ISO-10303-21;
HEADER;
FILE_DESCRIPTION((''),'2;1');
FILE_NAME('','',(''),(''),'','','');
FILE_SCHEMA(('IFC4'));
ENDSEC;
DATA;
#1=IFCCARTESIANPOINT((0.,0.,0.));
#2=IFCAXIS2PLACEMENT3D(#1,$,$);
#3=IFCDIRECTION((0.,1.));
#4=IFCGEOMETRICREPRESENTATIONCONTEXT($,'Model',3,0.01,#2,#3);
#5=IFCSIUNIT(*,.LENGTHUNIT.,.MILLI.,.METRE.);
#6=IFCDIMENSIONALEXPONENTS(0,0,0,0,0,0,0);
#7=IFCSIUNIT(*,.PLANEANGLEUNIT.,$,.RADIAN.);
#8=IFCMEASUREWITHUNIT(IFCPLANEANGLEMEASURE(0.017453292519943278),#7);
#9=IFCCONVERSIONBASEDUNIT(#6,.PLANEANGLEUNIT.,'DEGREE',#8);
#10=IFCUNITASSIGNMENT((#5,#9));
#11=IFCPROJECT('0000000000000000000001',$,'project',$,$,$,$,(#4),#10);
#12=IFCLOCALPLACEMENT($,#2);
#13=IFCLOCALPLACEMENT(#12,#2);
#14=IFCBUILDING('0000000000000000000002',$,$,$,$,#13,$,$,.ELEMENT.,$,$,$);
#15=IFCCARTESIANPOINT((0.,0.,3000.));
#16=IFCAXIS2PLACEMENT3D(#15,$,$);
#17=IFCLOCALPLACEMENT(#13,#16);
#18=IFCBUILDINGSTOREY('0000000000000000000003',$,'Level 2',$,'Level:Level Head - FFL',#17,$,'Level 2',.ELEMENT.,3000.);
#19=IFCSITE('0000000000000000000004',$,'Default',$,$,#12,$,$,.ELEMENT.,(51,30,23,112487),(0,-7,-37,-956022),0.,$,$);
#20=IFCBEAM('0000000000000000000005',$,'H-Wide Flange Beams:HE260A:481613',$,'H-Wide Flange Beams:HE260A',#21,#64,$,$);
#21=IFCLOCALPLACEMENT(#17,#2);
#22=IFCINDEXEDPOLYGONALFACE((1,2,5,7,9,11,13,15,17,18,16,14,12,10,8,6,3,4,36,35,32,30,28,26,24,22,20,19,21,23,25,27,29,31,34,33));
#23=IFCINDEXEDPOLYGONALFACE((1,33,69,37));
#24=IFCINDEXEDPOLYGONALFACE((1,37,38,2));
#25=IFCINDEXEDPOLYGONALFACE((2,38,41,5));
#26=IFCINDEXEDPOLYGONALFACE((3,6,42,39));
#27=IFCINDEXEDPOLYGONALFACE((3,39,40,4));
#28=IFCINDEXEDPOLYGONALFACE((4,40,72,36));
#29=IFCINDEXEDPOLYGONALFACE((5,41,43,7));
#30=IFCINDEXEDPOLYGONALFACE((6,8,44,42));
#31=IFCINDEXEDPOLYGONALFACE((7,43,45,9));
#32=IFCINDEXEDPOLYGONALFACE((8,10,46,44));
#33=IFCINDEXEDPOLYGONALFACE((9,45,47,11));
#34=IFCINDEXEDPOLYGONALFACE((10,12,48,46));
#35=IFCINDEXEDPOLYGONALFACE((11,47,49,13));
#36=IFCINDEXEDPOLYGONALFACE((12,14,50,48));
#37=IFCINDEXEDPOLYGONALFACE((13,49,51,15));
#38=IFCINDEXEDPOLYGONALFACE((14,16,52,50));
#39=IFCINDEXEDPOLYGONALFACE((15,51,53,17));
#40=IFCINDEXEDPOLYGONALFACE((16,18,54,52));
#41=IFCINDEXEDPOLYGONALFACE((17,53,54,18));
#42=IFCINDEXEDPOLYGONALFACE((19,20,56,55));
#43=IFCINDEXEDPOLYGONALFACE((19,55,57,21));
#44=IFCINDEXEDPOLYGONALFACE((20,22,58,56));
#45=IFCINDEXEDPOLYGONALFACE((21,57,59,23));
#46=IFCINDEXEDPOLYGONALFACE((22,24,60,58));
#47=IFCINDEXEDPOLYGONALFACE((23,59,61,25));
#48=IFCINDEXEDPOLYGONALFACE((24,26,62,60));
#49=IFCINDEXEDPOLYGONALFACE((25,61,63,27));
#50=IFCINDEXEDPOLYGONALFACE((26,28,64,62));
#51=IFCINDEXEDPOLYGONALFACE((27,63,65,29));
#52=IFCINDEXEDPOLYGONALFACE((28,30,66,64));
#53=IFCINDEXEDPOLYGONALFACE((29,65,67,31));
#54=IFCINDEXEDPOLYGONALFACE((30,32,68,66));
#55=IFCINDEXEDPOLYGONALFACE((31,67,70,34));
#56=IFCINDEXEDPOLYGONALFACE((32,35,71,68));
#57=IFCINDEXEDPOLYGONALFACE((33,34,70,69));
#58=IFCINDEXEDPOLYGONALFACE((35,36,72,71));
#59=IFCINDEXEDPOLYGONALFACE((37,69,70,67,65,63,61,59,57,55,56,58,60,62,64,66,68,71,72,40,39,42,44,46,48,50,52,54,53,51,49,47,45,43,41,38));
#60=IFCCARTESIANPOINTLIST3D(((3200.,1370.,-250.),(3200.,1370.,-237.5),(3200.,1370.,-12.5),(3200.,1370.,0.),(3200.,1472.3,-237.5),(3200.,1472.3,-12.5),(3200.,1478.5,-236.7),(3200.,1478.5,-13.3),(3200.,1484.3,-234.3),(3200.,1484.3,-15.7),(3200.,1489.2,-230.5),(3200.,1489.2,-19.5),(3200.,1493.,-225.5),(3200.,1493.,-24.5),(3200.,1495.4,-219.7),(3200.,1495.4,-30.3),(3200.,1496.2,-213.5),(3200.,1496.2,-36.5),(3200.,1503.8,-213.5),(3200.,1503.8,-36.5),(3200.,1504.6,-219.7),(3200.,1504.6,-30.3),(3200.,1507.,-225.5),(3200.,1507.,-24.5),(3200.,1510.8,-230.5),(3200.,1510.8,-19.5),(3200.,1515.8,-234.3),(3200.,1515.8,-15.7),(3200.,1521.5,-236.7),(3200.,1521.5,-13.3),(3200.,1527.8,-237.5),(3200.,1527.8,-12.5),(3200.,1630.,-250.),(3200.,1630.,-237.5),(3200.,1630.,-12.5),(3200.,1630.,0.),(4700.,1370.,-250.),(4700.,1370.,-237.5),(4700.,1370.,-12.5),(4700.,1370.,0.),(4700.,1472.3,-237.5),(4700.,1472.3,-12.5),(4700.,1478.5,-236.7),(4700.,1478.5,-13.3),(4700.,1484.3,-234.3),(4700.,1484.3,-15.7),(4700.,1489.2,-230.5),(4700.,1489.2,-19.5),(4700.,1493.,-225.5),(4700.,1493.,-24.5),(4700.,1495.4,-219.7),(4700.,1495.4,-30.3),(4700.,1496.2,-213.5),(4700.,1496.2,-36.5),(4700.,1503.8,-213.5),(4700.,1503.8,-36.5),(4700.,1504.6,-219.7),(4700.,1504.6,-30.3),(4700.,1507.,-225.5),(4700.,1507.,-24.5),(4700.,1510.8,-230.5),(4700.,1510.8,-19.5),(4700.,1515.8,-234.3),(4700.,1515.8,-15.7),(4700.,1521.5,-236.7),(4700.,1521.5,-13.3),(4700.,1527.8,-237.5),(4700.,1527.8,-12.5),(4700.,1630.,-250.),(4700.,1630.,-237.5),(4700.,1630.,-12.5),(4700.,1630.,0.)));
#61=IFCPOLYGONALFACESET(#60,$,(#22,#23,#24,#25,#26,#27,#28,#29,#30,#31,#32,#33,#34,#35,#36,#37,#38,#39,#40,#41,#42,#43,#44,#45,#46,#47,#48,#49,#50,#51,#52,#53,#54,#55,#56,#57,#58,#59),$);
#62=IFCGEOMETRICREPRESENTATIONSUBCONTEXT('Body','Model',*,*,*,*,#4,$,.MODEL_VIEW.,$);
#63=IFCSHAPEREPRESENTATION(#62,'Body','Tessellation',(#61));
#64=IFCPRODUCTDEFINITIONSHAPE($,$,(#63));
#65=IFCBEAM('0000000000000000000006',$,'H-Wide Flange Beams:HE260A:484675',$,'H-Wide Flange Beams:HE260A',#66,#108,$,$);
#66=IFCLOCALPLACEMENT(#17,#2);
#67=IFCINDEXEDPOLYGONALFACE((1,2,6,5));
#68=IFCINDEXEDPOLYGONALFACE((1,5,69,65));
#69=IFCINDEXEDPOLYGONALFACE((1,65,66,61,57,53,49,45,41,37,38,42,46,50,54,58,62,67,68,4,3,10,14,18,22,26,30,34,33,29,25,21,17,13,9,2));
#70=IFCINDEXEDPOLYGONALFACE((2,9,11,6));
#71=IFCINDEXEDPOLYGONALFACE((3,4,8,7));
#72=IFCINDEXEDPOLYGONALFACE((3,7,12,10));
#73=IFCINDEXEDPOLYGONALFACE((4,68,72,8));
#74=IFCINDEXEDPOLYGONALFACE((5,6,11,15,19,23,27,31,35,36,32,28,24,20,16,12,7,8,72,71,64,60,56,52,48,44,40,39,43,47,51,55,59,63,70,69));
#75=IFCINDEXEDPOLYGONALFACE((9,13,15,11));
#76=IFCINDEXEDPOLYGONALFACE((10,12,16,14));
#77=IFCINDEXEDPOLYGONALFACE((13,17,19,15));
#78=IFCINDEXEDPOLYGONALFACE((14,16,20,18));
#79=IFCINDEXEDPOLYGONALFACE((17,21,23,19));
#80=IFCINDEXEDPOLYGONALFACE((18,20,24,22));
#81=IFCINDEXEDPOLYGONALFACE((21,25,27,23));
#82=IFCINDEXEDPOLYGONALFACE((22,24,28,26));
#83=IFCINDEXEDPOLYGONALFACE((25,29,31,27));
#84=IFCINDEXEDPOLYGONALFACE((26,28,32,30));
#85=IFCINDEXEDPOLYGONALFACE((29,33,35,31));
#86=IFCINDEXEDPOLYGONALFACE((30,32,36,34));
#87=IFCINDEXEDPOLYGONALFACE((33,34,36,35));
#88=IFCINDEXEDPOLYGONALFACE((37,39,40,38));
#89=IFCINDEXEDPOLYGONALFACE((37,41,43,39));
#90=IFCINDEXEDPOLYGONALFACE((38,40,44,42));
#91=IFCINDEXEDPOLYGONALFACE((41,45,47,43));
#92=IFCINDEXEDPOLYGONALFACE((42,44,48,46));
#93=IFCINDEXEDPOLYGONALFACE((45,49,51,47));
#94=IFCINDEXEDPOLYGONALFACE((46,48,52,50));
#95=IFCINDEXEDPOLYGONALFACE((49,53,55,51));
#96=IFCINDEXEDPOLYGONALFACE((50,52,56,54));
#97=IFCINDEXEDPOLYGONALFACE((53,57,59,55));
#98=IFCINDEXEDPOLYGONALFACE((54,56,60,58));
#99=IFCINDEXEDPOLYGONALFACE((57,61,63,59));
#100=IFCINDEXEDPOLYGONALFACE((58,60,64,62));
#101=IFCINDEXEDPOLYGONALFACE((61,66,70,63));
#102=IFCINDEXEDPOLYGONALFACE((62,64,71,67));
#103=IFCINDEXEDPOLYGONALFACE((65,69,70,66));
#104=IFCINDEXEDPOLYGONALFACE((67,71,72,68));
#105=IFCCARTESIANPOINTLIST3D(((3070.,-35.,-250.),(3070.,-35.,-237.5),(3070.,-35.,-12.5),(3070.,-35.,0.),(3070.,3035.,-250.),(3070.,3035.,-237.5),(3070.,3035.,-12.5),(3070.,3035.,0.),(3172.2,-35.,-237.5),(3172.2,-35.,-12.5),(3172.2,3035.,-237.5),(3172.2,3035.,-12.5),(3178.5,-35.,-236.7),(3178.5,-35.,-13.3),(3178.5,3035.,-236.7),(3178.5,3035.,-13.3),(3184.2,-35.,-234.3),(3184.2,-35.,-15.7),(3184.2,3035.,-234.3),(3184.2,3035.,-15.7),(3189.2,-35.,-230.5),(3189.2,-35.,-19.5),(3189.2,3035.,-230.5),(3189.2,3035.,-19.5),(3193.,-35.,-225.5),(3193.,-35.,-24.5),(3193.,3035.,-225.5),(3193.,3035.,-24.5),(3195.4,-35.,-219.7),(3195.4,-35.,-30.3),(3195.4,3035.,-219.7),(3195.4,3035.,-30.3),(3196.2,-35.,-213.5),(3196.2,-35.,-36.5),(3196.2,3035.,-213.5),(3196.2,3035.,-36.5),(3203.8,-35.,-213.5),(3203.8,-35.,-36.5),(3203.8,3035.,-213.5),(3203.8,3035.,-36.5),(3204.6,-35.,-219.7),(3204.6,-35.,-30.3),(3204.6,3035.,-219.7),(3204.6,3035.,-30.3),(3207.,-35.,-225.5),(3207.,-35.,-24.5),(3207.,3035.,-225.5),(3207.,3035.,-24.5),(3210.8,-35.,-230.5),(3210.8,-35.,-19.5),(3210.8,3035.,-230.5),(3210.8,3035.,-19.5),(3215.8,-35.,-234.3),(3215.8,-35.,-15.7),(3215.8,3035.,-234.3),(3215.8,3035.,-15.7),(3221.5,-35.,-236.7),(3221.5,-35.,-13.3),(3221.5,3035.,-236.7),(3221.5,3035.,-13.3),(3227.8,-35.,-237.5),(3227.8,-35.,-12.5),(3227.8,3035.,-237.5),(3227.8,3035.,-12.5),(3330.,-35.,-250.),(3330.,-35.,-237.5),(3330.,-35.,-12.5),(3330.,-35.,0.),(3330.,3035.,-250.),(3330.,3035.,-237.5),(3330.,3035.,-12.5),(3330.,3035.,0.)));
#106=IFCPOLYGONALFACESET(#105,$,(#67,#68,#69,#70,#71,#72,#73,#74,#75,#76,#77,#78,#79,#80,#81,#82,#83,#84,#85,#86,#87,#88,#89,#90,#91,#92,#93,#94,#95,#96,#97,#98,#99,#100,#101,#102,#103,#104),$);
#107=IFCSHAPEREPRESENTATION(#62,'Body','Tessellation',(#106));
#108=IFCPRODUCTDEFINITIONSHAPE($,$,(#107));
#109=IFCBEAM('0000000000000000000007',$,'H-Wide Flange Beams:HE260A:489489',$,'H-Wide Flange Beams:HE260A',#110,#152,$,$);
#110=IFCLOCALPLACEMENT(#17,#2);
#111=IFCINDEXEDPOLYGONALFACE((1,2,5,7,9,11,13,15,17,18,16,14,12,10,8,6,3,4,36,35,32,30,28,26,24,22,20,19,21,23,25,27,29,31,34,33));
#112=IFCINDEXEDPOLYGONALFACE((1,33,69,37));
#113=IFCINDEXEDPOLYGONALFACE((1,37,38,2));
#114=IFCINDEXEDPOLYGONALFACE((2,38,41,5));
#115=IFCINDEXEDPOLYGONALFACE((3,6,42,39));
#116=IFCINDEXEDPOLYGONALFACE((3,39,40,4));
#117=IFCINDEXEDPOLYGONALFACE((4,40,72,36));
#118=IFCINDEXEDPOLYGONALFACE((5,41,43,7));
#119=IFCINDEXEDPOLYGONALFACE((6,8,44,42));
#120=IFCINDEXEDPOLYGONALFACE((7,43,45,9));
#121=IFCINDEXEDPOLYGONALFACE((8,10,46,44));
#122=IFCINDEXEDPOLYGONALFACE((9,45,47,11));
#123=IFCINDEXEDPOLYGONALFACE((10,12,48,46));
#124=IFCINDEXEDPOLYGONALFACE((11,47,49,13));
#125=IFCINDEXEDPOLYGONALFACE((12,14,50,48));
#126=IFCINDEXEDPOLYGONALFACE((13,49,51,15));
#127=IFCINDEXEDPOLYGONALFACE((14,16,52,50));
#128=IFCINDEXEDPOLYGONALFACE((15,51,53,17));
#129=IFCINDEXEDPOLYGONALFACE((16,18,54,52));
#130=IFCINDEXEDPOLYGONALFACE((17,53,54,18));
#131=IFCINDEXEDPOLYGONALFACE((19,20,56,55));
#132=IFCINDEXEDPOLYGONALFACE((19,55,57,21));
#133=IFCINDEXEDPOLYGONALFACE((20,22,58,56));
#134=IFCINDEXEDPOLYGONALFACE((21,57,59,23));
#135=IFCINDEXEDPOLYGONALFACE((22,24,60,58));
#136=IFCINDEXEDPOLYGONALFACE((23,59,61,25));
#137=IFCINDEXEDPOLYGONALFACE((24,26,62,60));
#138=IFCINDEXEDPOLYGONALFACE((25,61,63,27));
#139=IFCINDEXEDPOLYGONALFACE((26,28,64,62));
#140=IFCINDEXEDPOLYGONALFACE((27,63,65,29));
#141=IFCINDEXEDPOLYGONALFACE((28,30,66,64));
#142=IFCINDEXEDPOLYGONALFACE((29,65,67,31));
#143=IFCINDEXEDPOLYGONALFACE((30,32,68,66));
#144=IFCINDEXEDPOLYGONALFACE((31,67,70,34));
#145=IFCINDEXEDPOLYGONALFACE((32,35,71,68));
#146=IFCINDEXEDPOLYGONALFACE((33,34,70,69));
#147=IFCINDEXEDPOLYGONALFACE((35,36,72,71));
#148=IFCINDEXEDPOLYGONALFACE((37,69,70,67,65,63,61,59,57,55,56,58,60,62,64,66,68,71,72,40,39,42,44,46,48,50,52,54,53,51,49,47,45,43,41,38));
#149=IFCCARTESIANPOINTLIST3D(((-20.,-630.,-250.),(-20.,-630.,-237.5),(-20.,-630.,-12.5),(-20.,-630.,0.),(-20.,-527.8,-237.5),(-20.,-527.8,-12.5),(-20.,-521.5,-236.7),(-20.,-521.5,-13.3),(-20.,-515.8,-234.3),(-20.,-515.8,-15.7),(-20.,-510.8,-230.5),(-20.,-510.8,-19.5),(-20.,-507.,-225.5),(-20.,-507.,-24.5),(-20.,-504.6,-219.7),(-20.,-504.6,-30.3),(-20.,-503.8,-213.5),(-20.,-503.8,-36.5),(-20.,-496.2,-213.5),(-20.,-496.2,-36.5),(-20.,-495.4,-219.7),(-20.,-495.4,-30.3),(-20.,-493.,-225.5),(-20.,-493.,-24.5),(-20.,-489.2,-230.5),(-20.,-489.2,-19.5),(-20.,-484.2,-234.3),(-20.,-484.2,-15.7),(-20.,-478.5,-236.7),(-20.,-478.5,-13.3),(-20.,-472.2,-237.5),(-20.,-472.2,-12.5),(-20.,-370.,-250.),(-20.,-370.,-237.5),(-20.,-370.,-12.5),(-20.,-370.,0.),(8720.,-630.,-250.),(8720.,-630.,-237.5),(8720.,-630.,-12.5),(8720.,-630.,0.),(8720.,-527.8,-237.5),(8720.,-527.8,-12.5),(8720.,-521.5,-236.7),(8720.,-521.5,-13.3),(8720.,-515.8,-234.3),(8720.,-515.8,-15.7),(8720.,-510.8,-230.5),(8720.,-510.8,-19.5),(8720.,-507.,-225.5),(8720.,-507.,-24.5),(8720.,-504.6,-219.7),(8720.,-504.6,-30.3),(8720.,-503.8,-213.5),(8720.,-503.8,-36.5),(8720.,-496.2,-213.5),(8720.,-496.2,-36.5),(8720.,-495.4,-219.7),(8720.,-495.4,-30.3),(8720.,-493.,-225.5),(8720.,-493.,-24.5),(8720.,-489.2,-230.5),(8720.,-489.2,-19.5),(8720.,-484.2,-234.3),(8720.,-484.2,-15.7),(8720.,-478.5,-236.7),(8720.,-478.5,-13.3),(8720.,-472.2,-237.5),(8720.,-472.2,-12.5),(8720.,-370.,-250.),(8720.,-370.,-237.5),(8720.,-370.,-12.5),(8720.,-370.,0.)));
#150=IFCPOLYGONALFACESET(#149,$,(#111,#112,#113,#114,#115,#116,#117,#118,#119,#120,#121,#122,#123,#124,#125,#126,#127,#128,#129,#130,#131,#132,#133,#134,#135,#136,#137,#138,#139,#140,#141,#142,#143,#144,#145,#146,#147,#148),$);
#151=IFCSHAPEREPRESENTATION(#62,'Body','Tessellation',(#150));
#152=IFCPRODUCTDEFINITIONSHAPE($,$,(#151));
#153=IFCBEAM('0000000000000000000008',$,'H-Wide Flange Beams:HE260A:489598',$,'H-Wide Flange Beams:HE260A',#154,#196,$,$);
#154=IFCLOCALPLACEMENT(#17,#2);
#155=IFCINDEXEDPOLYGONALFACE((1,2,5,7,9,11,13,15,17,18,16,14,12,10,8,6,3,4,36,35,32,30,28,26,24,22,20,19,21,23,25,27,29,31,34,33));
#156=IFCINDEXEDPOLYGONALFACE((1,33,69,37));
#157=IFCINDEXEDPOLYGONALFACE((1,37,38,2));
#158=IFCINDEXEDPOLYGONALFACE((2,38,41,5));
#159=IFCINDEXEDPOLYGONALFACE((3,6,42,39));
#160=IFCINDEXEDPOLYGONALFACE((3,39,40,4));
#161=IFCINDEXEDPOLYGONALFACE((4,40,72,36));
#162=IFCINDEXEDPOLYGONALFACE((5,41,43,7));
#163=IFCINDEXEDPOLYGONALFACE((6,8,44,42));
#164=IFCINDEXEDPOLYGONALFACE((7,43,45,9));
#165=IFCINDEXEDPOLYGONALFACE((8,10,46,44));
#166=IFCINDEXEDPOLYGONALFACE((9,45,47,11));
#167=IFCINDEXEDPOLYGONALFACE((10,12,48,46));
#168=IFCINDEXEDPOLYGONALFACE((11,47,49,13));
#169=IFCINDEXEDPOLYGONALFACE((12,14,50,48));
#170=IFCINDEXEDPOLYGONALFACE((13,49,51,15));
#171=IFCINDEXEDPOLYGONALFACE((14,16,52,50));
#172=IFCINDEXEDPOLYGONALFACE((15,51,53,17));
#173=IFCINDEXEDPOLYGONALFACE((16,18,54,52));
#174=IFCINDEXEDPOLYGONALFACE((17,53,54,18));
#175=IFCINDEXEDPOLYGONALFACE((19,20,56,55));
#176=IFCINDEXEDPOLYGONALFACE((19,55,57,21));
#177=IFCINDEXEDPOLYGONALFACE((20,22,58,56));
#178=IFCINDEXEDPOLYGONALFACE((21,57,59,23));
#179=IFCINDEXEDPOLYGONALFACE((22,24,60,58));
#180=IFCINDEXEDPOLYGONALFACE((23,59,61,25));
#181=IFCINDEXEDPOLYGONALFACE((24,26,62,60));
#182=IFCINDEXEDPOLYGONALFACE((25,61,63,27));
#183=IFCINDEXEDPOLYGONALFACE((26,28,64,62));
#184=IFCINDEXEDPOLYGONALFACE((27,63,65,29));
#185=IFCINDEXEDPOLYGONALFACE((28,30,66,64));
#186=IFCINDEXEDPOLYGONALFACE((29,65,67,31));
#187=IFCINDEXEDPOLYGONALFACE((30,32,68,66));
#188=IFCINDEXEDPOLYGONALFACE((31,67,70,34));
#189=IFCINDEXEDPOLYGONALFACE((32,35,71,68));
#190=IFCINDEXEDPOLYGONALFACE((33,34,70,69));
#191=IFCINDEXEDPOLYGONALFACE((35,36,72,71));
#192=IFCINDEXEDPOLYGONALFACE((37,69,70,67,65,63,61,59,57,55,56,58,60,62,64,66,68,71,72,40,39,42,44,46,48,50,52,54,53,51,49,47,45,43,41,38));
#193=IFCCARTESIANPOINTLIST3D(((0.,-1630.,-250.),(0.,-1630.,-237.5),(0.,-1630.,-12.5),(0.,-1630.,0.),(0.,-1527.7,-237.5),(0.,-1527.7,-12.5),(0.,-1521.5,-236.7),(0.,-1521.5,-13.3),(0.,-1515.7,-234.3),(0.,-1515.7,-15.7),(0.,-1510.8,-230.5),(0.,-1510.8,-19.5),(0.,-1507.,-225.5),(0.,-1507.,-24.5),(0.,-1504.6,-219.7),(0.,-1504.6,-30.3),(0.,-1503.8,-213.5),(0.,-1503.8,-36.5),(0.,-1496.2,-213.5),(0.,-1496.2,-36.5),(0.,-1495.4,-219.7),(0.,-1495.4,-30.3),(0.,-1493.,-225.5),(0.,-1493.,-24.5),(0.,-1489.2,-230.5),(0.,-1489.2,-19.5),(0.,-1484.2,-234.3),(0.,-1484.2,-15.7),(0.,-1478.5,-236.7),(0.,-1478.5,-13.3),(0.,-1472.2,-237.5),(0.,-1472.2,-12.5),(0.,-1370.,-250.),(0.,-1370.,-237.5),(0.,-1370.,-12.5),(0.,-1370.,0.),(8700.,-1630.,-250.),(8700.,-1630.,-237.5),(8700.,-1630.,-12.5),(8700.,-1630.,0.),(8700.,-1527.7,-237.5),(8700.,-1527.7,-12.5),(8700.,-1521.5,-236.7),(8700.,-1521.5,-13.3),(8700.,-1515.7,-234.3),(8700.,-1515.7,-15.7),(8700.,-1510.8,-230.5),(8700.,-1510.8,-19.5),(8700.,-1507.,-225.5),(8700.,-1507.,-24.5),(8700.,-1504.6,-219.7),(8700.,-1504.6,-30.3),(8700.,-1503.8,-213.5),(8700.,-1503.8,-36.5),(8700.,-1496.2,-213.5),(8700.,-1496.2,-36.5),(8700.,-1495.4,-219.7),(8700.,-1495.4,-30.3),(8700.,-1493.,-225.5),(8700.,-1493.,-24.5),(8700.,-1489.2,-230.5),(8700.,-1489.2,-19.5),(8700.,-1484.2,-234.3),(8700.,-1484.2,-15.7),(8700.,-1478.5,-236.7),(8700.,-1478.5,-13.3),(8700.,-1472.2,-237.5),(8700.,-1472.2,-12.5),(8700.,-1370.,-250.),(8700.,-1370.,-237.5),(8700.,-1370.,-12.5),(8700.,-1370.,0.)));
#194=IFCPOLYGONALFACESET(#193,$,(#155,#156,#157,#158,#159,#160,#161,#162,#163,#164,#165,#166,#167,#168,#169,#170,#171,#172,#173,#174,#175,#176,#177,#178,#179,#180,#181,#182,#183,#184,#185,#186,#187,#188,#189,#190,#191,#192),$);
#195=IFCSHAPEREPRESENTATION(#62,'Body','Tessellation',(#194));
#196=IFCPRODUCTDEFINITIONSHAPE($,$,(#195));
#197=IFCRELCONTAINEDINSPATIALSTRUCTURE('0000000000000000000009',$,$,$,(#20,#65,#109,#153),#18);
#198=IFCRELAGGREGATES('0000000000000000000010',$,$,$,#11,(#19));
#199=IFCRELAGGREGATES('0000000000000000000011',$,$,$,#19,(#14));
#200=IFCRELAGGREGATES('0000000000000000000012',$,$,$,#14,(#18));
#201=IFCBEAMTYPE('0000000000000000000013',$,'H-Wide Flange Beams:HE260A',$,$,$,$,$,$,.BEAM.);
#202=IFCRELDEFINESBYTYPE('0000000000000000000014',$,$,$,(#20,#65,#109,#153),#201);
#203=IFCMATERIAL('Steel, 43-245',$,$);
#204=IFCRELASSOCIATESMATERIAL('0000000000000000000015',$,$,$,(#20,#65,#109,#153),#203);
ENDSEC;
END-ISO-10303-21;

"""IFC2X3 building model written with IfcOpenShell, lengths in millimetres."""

from ifc_helpers import new_model, entity, si_unit, converted_unit, direction, frame, frame_2d, origin, place, context, subcontext, project, spatial, i_section, extrude, material, type_object, element, save


model = new_model("IFC2X3")

# Units and contexts
model_context = context("Model", 3, precision=0.01, world=origin(), true_north=direction((0.0, 1.0)))
body_context = subcontext(model_context, "Body", "Model", "MODEL_VIEW")
ifc_project = project(units=[si_unit("LENGTHUNIT", "METRE", prefix="MILLI"), converted_unit("PLANEANGLEUNIT", "DEGREE", entity("IfcPlaneAngleMeasure", 0.017453292519943278), si_unit("PLANEANGLEUNIT", "RADIAN"), dimensions=[0, 0, 0, 0, 0, 0, 0])], contexts=[model_context])

# Site, building, storey
site_placement = place(None, origin())
site = spatial("IfcSite", under=ifc_project, at=site_placement, Name="Default", CompositionType="ELEMENT", RefLatitude=(51, 30, 23, 112487), RefLongitude=(0, -7, -37, -956022), RefElevation=0.0)
building_placement = place(site_placement, origin())
building = spatial("IfcBuilding", under=site, at=building_placement, CompositionType="ELEMENT")
storey_placement = place(building_placement, frame((0.0, 0.0, 3000.0)))
storey = spatial("IfcBuildingStorey", under=building, at=storey_placement, Name="Level 2", ObjectType="Level:Level Head - FFL", LongName="Level 2", CompositionType="ELEMENT", Elevation=3000.0)

# Beams
ifc_material = material(Name="Steel, 43-245")
beam_type_1 = type_object("IfcBeamType", Name="H-Wide Flange Beams:HE260A", PredefinedType="BEAM")
beam_1_placement = place(storey_placement, frame((4700.0, 1500.0, 0.0), z_axis=(0.0, 0.0, 1.0), x_axis=(-1.0, 0.0, 0.0)))
element("IfcBeam", 1, at=beam_1_placement, inside=storey, type_object=beam_type_1, material=ifc_material, Name="H-Wide Flange Beams:HE260A:481613", ObjectType="H-Wide Flange Beams:HE260A", context=body_context, shape_type="SweptSolid", body=[
    extrude(i_section(OverallWidth=260.0, OverallDepth=250.0, WebThickness=7.5, FlangeThickness=12.5, FilletRadius=24.0, at=frame_2d((0.0, 0.0), x_axis=(0.0, 1.0))), frame((0.0, 0.0, -125.0), z_axis=(1.0, 0.0, 0.0), x_axis=(0.0, 0.0, -1.0)), (0.0, 0.0, 1.0), 1500.0),
])
beam_2_placement = place(storey_placement, frame((3200.0, 0.0, 0.0), z_axis=(0.0, 0.0, 1.0), x_axis=(0.0, 1.0, 0.0)))
element("IfcBeam", 2, at=beam_2_placement, inside=storey, type_object=beam_type_1, material=ifc_material, Name="H-Wide Flange Beams:HE260A:484675", ObjectType="H-Wide Flange Beams:HE260A", context=body_context, shape_type="SweptSolid", body=[
    extrude(i_section(OverallWidth=260.0, OverallDepth=250.0, WebThickness=7.5, FlangeThickness=12.5, FilletRadius=24.0, at=frame_2d((0.0, 0.0), x_axis=(0.0, 1.0))), frame((-35.0, 0.0, -125.0), z_axis=(1.0, 0.0, 0.0), x_axis=(0.0, 0.0, -1.0)), (0.0, 0.0, 1.0), 3070.0),
])
beam_3_placement = place(storey_placement, frame((0.0, -500.0, 0.0)))
element("IfcBeam", 3, at=beam_3_placement, inside=storey, type_object=beam_type_1, material=ifc_material, Name="H-Wide Flange Beams:HE260A:489489", ObjectType="H-Wide Flange Beams:HE260A", context=body_context, shape_type="SweptSolid", body=[
    extrude(i_section(OverallWidth=260.0, OverallDepth=250.0, WebThickness=7.5, FlangeThickness=12.5, FilletRadius=24.0, at=frame_2d((0.0, 0.0), x_axis=(0.0, 1.0))), frame((-20.0, 0.0, -125.0), z_axis=(1.0, 0.0, 0.0), x_axis=(0.0, 0.0, -1.0)), (0.0, 0.0, 1.0), 8740.0),
])
beam_4_placement = place(storey_placement, frame((0.0, -1500.0, 0.0)))
element("IfcBeam", 4, at=beam_4_placement, inside=storey, type_object=beam_type_1, material=ifc_material, Name="H-Wide Flange Beams:HE260A:489598", ObjectType="H-Wide Flange Beams:HE260A", context=body_context, shape_type="SweptSolid", body=[
    extrude(i_section(OverallWidth=260.0, OverallDepth=250.0, WebThickness=7.5, FlangeThickness=12.5, FilletRadius=24.0, at=frame_2d((0.0, 0.0), x_axis=(0.0, 1.0))), frame((0.0, 0.0, -125.0), z_axis=(1.0, 0.0, 0.0), x_axis=(0.0, 0.0, -1.0)), (0.0, 0.0, 1.0), 8700.0),
])

save(model, "model.ifc")
